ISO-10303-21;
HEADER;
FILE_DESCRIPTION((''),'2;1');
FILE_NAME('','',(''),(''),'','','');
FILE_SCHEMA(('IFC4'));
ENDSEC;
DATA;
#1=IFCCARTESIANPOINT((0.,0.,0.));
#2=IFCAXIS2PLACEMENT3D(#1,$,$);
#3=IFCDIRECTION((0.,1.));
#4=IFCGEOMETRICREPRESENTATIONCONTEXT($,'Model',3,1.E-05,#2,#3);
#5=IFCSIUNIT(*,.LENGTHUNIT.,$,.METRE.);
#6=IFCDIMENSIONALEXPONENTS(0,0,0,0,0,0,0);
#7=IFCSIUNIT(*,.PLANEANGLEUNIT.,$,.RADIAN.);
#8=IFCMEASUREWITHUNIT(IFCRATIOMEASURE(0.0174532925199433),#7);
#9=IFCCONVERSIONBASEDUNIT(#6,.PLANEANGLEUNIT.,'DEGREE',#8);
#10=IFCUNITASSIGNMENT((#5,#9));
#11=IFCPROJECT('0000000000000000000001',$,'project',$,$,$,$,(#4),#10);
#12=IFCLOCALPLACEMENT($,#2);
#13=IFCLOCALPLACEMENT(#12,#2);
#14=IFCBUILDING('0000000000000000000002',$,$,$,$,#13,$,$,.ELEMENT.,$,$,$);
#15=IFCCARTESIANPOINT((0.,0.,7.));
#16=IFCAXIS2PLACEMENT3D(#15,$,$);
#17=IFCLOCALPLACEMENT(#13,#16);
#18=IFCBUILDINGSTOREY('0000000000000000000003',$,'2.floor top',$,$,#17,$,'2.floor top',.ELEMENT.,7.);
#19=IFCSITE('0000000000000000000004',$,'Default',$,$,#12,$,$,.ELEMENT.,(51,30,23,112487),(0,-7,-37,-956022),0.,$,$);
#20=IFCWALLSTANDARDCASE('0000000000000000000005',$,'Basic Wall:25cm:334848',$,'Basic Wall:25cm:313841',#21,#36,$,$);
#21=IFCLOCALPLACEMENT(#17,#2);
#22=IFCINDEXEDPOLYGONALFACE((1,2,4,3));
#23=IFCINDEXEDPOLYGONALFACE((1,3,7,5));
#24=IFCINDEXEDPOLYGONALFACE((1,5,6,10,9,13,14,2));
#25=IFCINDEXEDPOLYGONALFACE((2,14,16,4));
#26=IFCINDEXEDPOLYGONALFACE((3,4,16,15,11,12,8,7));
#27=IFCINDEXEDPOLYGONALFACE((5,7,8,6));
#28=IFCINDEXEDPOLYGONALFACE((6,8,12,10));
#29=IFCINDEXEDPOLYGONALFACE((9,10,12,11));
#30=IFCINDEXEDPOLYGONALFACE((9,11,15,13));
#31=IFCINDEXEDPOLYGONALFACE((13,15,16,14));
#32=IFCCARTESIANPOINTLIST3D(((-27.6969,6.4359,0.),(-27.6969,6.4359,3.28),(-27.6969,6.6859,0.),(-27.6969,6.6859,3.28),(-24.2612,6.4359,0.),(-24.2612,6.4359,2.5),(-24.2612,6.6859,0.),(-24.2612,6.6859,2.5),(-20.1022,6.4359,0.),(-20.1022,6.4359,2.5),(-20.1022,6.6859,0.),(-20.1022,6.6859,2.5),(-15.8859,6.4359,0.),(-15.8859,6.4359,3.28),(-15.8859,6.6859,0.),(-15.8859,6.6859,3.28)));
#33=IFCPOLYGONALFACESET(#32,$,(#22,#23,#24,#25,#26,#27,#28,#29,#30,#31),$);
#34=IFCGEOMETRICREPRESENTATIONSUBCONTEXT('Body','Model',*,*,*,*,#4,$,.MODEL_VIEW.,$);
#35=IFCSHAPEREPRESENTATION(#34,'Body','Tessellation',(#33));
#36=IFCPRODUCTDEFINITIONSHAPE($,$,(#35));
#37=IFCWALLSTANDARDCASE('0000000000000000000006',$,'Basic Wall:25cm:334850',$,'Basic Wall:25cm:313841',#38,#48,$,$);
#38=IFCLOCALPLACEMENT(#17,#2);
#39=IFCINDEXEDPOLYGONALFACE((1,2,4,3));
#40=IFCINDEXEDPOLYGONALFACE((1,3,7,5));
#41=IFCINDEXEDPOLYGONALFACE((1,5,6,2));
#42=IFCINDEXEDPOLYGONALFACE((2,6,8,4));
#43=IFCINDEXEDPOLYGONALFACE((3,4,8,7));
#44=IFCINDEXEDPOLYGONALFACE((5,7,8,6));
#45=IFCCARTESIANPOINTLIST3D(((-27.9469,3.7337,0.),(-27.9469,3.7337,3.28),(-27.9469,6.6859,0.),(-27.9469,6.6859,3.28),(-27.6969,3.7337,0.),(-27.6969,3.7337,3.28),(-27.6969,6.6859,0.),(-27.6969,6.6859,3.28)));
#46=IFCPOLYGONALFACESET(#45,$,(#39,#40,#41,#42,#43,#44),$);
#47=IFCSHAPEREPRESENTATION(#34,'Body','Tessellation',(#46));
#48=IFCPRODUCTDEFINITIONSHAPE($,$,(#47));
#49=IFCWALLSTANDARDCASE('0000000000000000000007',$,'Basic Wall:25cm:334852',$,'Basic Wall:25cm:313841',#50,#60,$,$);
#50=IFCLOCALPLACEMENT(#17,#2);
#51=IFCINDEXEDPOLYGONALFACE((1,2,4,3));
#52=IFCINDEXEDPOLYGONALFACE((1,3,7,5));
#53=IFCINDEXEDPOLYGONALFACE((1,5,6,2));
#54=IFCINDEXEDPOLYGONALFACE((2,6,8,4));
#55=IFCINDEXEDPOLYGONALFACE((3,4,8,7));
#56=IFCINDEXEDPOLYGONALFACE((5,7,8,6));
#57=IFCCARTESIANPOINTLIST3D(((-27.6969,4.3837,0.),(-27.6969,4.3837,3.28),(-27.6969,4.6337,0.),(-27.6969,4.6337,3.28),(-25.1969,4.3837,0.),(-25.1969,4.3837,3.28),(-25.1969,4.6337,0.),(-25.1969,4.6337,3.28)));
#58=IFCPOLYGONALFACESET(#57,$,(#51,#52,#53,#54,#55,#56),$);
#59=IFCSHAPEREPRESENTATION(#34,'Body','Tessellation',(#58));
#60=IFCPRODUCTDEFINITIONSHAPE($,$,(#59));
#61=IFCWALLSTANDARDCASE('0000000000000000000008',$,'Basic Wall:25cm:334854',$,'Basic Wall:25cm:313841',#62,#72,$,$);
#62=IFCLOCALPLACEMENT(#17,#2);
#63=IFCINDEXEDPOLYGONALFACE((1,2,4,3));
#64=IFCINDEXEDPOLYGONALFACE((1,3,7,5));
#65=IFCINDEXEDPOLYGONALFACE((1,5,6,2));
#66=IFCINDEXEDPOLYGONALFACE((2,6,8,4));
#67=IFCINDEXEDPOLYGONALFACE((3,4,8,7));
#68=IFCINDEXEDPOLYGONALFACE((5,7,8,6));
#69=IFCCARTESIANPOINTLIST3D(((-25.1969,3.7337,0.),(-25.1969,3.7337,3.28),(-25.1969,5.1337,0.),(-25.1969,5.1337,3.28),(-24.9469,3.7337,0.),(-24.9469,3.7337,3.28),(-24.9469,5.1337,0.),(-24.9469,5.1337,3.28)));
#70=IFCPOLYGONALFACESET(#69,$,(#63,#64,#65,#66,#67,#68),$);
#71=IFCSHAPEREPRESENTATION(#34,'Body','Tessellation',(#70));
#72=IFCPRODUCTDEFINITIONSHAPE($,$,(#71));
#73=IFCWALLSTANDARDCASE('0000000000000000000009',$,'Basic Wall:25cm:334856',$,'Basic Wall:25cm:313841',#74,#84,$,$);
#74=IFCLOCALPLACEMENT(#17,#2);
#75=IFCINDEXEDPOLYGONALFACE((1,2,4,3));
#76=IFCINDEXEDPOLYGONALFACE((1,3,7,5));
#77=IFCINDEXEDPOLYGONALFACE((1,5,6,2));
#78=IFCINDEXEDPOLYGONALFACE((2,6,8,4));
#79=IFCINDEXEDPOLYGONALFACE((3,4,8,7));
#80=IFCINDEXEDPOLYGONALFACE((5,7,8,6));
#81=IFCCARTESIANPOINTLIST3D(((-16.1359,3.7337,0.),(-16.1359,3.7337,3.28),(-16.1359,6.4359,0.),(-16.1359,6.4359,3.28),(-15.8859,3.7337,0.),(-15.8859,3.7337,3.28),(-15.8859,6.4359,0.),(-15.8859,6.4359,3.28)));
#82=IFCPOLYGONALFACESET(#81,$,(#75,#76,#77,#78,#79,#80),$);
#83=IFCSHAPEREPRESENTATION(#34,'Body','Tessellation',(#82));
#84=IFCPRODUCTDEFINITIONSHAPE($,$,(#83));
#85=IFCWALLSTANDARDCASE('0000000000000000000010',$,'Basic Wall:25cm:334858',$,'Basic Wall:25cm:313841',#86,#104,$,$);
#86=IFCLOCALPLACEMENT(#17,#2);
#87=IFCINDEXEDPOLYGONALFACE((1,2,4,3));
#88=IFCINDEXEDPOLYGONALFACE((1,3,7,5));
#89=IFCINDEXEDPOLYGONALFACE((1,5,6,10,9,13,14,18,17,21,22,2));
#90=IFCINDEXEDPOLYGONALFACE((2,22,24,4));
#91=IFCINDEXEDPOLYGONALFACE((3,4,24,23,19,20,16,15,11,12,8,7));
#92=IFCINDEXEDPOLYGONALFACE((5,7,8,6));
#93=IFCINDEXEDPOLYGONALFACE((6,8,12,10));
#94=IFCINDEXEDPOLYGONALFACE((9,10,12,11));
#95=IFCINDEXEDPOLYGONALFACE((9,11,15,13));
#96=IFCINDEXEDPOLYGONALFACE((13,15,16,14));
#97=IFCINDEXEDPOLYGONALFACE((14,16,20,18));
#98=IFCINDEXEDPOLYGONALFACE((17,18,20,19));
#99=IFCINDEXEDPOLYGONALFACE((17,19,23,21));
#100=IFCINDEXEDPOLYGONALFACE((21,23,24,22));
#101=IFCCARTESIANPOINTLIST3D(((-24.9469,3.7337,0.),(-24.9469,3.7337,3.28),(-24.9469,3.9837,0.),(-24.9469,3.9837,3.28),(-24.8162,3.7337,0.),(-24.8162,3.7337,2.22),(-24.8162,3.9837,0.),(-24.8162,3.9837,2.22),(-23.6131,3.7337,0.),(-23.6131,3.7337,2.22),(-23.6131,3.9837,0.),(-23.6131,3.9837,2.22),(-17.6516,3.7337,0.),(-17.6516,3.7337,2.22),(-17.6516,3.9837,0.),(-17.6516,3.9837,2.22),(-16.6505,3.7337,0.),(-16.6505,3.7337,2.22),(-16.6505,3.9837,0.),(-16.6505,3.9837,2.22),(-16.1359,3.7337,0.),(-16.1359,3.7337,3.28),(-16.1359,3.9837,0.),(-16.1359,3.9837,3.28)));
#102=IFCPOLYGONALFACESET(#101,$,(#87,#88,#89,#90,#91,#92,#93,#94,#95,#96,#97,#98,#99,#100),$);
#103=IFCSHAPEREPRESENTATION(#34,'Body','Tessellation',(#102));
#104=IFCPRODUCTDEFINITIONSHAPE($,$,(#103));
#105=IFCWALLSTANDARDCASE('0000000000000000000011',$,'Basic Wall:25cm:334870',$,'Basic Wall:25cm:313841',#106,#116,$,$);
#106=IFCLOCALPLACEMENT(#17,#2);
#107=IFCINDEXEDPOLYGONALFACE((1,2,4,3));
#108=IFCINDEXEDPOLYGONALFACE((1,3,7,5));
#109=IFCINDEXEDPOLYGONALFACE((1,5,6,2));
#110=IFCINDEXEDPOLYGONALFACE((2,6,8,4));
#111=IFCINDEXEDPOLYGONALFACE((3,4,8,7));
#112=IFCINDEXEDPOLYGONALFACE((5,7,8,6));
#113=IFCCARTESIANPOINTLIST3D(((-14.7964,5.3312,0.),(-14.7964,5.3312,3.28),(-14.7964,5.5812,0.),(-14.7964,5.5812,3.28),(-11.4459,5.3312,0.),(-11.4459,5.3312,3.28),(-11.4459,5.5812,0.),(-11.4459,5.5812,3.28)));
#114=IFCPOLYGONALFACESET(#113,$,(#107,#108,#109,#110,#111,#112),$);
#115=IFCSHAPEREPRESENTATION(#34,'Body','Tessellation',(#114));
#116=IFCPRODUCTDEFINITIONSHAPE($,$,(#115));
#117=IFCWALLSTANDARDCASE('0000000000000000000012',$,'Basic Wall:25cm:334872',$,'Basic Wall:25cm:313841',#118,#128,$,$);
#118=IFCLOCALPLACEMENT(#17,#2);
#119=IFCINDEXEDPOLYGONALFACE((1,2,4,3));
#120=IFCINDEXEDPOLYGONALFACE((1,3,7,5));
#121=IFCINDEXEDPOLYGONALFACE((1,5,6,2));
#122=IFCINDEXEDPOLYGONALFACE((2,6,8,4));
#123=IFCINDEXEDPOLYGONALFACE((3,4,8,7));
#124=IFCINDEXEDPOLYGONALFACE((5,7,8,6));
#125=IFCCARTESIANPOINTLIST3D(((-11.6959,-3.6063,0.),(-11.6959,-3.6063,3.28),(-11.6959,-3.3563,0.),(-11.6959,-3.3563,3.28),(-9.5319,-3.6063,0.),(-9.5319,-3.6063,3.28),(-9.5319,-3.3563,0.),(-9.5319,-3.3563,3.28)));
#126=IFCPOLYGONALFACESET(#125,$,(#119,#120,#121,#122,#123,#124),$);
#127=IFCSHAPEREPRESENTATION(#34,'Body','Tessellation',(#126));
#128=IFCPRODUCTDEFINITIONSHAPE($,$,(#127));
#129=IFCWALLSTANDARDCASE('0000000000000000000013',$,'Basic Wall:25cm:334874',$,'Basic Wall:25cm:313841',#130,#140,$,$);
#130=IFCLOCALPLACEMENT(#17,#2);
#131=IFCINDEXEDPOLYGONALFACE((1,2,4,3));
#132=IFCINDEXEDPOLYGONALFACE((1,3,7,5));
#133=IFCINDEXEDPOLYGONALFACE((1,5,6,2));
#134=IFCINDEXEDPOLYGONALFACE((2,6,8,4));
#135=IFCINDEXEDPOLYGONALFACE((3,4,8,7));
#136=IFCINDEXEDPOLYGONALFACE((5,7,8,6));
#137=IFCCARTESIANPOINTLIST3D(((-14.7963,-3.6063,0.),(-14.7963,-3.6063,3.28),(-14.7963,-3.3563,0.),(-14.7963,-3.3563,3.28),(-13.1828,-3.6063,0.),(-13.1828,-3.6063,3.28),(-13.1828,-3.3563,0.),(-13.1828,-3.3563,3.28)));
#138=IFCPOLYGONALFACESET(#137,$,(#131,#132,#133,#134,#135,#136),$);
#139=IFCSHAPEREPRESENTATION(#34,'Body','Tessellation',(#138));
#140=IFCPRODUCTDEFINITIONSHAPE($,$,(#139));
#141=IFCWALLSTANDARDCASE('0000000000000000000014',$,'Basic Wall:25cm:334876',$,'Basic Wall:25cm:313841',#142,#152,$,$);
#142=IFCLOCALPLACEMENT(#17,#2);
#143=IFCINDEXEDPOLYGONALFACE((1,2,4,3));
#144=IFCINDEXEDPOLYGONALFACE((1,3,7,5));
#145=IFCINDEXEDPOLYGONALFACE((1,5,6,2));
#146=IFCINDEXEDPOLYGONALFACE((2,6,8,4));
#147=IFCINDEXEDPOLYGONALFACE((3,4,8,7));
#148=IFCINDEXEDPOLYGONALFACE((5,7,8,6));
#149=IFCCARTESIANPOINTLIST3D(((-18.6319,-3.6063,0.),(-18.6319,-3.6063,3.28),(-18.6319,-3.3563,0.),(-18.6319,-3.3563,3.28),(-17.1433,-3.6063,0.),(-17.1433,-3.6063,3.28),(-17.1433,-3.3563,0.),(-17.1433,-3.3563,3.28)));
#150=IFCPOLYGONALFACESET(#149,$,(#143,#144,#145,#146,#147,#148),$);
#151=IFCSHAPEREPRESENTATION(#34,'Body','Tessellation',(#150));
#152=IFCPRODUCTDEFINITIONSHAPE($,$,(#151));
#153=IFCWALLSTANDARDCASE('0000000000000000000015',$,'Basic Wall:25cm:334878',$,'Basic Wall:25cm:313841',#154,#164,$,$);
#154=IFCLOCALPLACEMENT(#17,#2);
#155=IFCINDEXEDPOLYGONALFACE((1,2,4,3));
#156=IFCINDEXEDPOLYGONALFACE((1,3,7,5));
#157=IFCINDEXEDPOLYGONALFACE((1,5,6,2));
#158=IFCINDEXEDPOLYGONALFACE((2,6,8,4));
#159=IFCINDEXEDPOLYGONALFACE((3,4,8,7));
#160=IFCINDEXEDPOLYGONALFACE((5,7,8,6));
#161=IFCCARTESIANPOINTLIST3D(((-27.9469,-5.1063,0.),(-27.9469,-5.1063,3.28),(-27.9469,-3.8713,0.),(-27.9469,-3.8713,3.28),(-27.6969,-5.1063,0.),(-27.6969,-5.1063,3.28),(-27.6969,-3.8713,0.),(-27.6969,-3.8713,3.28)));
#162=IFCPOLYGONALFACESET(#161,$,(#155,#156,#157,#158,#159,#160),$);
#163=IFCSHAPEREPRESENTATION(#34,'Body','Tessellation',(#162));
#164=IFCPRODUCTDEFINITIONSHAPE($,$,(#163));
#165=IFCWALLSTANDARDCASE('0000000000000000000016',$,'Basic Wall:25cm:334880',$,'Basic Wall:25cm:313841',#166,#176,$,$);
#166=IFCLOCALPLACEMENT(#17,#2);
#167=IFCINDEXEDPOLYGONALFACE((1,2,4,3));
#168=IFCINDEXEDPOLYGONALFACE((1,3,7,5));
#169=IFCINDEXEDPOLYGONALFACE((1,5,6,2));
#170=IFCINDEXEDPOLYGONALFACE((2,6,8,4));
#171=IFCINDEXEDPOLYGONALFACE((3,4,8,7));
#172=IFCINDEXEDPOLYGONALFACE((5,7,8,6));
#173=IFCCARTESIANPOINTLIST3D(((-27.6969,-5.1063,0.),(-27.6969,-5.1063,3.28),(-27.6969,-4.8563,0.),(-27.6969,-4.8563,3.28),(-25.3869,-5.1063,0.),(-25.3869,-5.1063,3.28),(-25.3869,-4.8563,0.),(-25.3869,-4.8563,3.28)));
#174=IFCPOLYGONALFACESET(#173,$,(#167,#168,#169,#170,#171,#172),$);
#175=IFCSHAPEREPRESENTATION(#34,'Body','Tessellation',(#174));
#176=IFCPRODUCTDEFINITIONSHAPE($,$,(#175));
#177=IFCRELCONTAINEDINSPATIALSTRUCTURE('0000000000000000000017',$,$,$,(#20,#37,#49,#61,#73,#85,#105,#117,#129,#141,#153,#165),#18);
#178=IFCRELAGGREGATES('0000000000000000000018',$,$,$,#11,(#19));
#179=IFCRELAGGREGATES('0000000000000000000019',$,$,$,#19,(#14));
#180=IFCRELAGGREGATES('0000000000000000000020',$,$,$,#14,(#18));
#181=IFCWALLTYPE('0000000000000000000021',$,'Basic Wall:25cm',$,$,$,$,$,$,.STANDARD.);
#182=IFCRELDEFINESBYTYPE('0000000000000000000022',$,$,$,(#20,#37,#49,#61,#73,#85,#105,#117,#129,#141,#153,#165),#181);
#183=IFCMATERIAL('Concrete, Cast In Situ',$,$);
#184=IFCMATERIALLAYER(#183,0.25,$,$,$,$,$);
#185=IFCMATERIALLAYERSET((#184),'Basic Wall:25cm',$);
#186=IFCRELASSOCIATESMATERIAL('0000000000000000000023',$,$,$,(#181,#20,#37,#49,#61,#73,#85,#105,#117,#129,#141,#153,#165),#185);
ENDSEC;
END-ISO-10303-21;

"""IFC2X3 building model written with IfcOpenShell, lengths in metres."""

from ifc_helpers import new_model, entity, si_unit, converted_unit, direction, frame, frame_2d, origin, place, context, subcontext, project, spatial, rectangle, extrude, material, layer, layer_set, layer_usage, type_object, element, save


model = new_model("IFC2X3")

# Units and contexts
model_context = context("Model", 3, precision=1e-05, world=origin(), true_north=direction((0.0, 1.0)))
body_context = subcontext(model_context, "Body", "Model", "MODEL_VIEW")
ifc_project = project(units=[si_unit("LENGTHUNIT", "METRE"), converted_unit("PLANEANGLEUNIT", "DEGREE", entity("IfcRatioMeasure", 0.0174532925199433), si_unit("PLANEANGLEUNIT", "RADIAN"), dimensions=[0, 0, 0, 0, 0, 0, 0])], contexts=[model_context])

# Site, building, storey
site_placement = place(None, origin())
site = spatial("IfcSite", under=ifc_project, at=site_placement, Name="Default", CompositionType="ELEMENT", RefLatitude=(51, 30, 23, 112487), RefLongitude=(0, -7, -37, -956022), RefElevation=0.0)
building_placement = place(site_placement, origin())
building = spatial("IfcBuilding", under=site, at=building_placement, CompositionType="ELEMENT")
storey_placement = place(building_placement, frame((0.0, 0.0, 7.0)))
storey = spatial("IfcBuildingStorey", under=building, at=storey_placement, Name="2.floor top", LongName="2.floor top", CompositionType="ELEMENT", Elevation=7.0)

# Wall, opening
ifc_material = material(Name="Concrete, Cast In Situ")
ifc_layer = layer(ifc_material, 0.25)
ifc_layer_set = layer_set([ifc_layer], Name="Basic Wall:25cm")
ifc_layer_usage_1 = layer_usage(ifc_layer_set, "AXIS2", "NEGATIVE", 0.125)
wall_type = type_object("IfcWallType", Name="Basic Wall:25cm", PredefinedType="STANDARD", material=ifc_layer_set)
wall_1_placement = place(storey_placement, frame((-15.8859, 6.5609, 0.0), z_axis=(0.0, 0.0, 1.0), x_axis=(-1.0, 0.0, 0.0)))
wall_1 = element("IfcWallStandardCase", 1, at=wall_1_placement, inside=storey, type_object=wall_type, material=ifc_layer_usage_1, Name="Basic Wall:25cm:334848", ObjectType="Basic Wall:25cm:313841", context=body_context, shape_type="SweptSolid", body=[
    extrude(rectangle(XDim=11.811, YDim=0.25, at=frame_2d((5.9055, 0.0), x_axis=(-1.0, 0.0))), origin(), (0.0, 0.0, 1.0), 3.28),
])
opening_1_placement = place(wall_1_placement, origin())
element("IfcOpeningElement", 2, at=opening_1_placement, cuts=wall_1, ObjectType="Opening", context=body_context, shape_type="SweptSolid", body=[
    extrude(rectangle(XDim=2.5, YDim=4.1591, at=frame_2d((0.0, 0.0), x_axis=(1.0, 0.0))), frame((6.2958, -0.125, 1.25), z_axis=(0.0, 1.0, 0.0), x_axis=(0.0, 0.0, -1.0)), (0.0, 0.0, 1.0), 0.25),
])

# Walls
ifc_layer_usage_2 = layer_usage(ifc_layer_set, "AXIS2", "NEGATIVE", 0.125)
wall_2_placement = place(storey_placement, frame((-27.8219, 6.6859, 0.0), z_axis=(0.0, 0.0, 1.0), x_axis=(0.0, -1.0, 0.0)))
element("IfcWallStandardCase", 3, at=wall_2_placement, inside=storey, type_object=wall_type, material=ifc_layer_usage_2, Name="Basic Wall:25cm:334850", ObjectType="Basic Wall:25cm:313841", context=body_context, shape_type="SweptSolid", body=[
    extrude(rectangle(XDim=2.9523, YDim=0.25, at=frame_2d((1.4761, 0.0), x_axis=(-1.0, 0.0))), origin(), (0.0, 0.0, 1.0), 3.28),
])
ifc_layer_usage_3 = layer_usage(ifc_layer_set, "AXIS2", "POSITIVE", -0.125)
wall_3_placement = place(storey_placement, frame((-27.6969, 4.5087, 0.0)))
element("IfcWallStandardCase", 4, at=wall_3_placement, inside=storey, type_object=wall_type, material=ifc_layer_usage_3, Name="Basic Wall:25cm:334852", ObjectType="Basic Wall:25cm:313841", context=body_context, shape_type="SweptSolid", body=[
    extrude(rectangle(XDim=2.5, YDim=0.25, at=frame_2d((1.25, 0.0), x_axis=(-1.0, 0.0))), origin(), (0.0, 0.0, 1.0), 3.28),
])
ifc_layer_usage_4 = layer_usage(ifc_layer_set, "AXIS2", "NEGATIVE", 0.125)
wall_4_placement = place(storey_placement, frame((-25.0719, 5.1337, 0.0), z_axis=(0.0, 0.0, 1.0), x_axis=(0.0, -1.0, 0.0)))
element("IfcWallStandardCase", 5, at=wall_4_placement, inside=storey, type_object=wall_type, material=ifc_layer_usage_4, Name="Basic Wall:25cm:334854", ObjectType="Basic Wall:25cm:313841", context=body_context, shape_type="SweptSolid", body=[
    extrude(rectangle(XDim=1.4, YDim=0.25, at=frame_2d((0.7, 0.0), x_axis=(-1.0, 0.0))), origin(), (0.0, 0.0, 1.0), 3.28),
])
ifc_layer_usage_5 = layer_usage(ifc_layer_set, "AXIS2", "POSITIVE", -0.125)
wall_5_placement = place(storey_placement, frame((-16.0109, 6.4359, 0.0), z_axis=(0.0, 0.0, 1.0), x_axis=(0.0, -1.0, 0.0)))
element("IfcWallStandardCase", 6, at=wall_5_placement, inside=storey, type_object=wall_type, material=ifc_layer_usage_5, Name="Basic Wall:25cm:334856", ObjectType="Basic Wall:25cm:313841", context=body_context, shape_type="SweptSolid", body=[
    extrude(rectangle(XDim=2.7022, YDim=0.25, at=frame_2d((1.3511, 0.0), x_axis=(-1.0, 0.0))), origin(), (0.0, 0.0, 1.0), 3.28),
])

# Wall, openings
ifc_layer_usage_6 = layer_usage(ifc_layer_set, "AXIS2", "POSITIVE", -0.125)
wall_6_placement = place(storey_placement, frame((-16.1359, 3.8587, 0.0), z_axis=(0.0, 0.0, 1.0), x_axis=(-1.0, -0.000001, 0.0)))
wall_6 = element("IfcWallStandardCase", 7, at=wall_6_placement, inside=storey, type_object=wall_type, material=ifc_layer_usage_6, Name="Basic Wall:25cm:334858", ObjectType="Basic Wall:25cm:313841", context=body_context, shape_type="SweptSolid", body=[
    extrude(rectangle(XDim=8.811, YDim=0.25, at=frame_2d((4.4055, 0.0), x_axis=(-1.0, 0.0))), origin(), (0.0, 0.0, 1.0), 3.28),
])
opening_2_placement = place(wall_6_placement, origin())
element("IfcOpeningElement", 8, at=opening_2_placement, cuts=wall_6, ObjectType="Opening", context=body_context, shape_type="SweptSolid", body=[
    extrude(rectangle(XDim=2.22, YDim=1.2031, at=frame_2d((0.0, 0.0), x_axis=(1.0, 0.0))), frame((8.0788, -0.125, 1.11), z_axis=(0.0, 1.0, 0.0), x_axis=(0.0, 0.0, -1.0)), (0.0, 0.0, 1.0), 0.25),
])
opening_3_placement = place(wall_6_placement, origin())
element("IfcOpeningElement", 9, at=opening_3_placement, cuts=wall_6, ObjectType="Opening", context=body_context, shape_type="SweptSolid", body=[
    extrude(rectangle(XDim=2.22, YDim=1.0011, at=frame_2d((0.0, 0.0), x_axis=(1.0, 0.0))), frame((1.0152, -0.125, 1.11), z_axis=(0.0, 1.0, 0.0), x_axis=(0.0, 0.0, -1.0)), (0.0, 0.0, 1.0), 0.25),
])

# Walls
ifc_layer_usage_7 = layer_usage(ifc_layer_set, "AXIS2", "POSITIVE", -0.125)
wall_7_placement = place(storey_placement, frame((-14.7964, 5.4562, 0.0)))
element("IfcWallStandardCase", 10, at=wall_7_placement, inside=storey, type_object=wall_type, material=ifc_layer_usage_7, Name="Basic Wall:25cm:334870", ObjectType="Basic Wall:25cm:313841", context=body_context, shape_type="SweptSolid", body=[
    extrude(rectangle(XDim=3.3505, YDim=0.25, at=frame_2d((1.6752, 0.0), x_axis=(-1.0, 0.0))), origin(), (0.0, 0.0, 1.0), 3.28),
])
ifc_layer_usage_8 = layer_usage(ifc_layer_set, "AXIS2", "NEGATIVE", 0.125)
wall_8_placement = place(storey_placement, frame((-11.6959, -3.4813, 0.0)))
element("IfcWallStandardCase", 11, at=wall_8_placement, inside=storey, type_object=wall_type, material=ifc_layer_usage_8, Name="Basic Wall:25cm:334872", ObjectType="Basic Wall:25cm:313841", context=body_context, shape_type="SweptSolid", body=[
    extrude(rectangle(XDim=2.164, YDim=0.25, at=frame_2d((1.082, 0.0), x_axis=(-1.0, 0.0))), origin(), (0.0, 0.0, 1.0), 3.28),
])
ifc_layer_usage_9 = layer_usage(ifc_layer_set, "AXIS2", "POSITIVE", -0.125)
wall_9_placement = place(storey_placement, frame((-13.1828, -3.4813, 0.0), z_axis=(0.0, 0.0, 1.0), x_axis=(-1.0, 0.0, 0.0)))
element("IfcWallStandardCase", 12, at=wall_9_placement, inside=storey, type_object=wall_type, material=ifc_layer_usage_9, Name="Basic Wall:25cm:334874", ObjectType="Basic Wall:25cm:313841", context=body_context, shape_type="SweptSolid", body=[
    extrude(rectangle(XDim=1.6135, YDim=0.25, at=frame_2d((0.8068, 0.0), x_axis=(-1.0, 0.0))), origin(), (0.0, 0.0, 1.0), 3.28),
])
ifc_layer_usage_10 = layer_usage(ifc_layer_set, "AXIS2", "NEGATIVE", 0.125)
wall_10_placement = place(storey_placement, frame((-18.6319, -3.4813, 0.0)))
element("IfcWallStandardCase", 13, at=wall_10_placement, inside=storey, type_object=wall_type, material=ifc_layer_usage_10, Name="Basic Wall:25cm:334876", ObjectType="Basic Wall:25cm:313841", context=body_context, shape_type="SweptSolid", body=[
    extrude(rectangle(XDim=1.4886, YDim=0.25, at=frame_2d((0.7443, 0.0), x_axis=(-1.0, 0.0))), origin(), (0.0, 0.0, 1.0), 3.28),
])
ifc_layer_usage_11 = layer_usage(ifc_layer_set, "AXIS2", "NEGATIVE", 0.125)
wall_11_placement = place(storey_placement, frame((-27.8219, -3.8713, 0.0), z_axis=(0.0, 0.0, 1.0), x_axis=(0.0, -1.0, 0.0)))
element("IfcWallStandardCase", 14, at=wall_11_placement, inside=storey, type_object=wall_type, material=ifc_layer_usage_11, Name="Basic Wall:25cm:334878", ObjectType="Basic Wall:25cm:313841", context=body_context, shape_type="SweptSolid", body=[
    extrude(rectangle(XDim=1.235, YDim=0.25, at=frame_2d((0.6175, 0.0), x_axis=(-1.0, 0.0))), origin(), (0.0, 0.0, 1.0), 3.28),
])
ifc_layer_usage_12 = layer_usage(ifc_layer_set, "AXIS2", "NEGATIVE", 0.125)
wall_12_placement = place(storey_placement, frame((-27.6969, -4.9813, 0.0)))
element("IfcWallStandardCase", 15, at=wall_12_placement, inside=storey, type_object=wall_type, material=ifc_layer_usage_12, Name="Basic Wall:25cm:334880", ObjectType="Basic Wall:25cm:313841", context=body_context, shape_type="SweptSolid", body=[
    extrude(rectangle(XDim=2.31, YDim=0.25, at=frame_2d((1.155, 0.0), x_axis=(-1.0, 0.0))), origin(), (0.0, 0.0, 1.0), 3.28),
])

save(model, "model.ifc")
